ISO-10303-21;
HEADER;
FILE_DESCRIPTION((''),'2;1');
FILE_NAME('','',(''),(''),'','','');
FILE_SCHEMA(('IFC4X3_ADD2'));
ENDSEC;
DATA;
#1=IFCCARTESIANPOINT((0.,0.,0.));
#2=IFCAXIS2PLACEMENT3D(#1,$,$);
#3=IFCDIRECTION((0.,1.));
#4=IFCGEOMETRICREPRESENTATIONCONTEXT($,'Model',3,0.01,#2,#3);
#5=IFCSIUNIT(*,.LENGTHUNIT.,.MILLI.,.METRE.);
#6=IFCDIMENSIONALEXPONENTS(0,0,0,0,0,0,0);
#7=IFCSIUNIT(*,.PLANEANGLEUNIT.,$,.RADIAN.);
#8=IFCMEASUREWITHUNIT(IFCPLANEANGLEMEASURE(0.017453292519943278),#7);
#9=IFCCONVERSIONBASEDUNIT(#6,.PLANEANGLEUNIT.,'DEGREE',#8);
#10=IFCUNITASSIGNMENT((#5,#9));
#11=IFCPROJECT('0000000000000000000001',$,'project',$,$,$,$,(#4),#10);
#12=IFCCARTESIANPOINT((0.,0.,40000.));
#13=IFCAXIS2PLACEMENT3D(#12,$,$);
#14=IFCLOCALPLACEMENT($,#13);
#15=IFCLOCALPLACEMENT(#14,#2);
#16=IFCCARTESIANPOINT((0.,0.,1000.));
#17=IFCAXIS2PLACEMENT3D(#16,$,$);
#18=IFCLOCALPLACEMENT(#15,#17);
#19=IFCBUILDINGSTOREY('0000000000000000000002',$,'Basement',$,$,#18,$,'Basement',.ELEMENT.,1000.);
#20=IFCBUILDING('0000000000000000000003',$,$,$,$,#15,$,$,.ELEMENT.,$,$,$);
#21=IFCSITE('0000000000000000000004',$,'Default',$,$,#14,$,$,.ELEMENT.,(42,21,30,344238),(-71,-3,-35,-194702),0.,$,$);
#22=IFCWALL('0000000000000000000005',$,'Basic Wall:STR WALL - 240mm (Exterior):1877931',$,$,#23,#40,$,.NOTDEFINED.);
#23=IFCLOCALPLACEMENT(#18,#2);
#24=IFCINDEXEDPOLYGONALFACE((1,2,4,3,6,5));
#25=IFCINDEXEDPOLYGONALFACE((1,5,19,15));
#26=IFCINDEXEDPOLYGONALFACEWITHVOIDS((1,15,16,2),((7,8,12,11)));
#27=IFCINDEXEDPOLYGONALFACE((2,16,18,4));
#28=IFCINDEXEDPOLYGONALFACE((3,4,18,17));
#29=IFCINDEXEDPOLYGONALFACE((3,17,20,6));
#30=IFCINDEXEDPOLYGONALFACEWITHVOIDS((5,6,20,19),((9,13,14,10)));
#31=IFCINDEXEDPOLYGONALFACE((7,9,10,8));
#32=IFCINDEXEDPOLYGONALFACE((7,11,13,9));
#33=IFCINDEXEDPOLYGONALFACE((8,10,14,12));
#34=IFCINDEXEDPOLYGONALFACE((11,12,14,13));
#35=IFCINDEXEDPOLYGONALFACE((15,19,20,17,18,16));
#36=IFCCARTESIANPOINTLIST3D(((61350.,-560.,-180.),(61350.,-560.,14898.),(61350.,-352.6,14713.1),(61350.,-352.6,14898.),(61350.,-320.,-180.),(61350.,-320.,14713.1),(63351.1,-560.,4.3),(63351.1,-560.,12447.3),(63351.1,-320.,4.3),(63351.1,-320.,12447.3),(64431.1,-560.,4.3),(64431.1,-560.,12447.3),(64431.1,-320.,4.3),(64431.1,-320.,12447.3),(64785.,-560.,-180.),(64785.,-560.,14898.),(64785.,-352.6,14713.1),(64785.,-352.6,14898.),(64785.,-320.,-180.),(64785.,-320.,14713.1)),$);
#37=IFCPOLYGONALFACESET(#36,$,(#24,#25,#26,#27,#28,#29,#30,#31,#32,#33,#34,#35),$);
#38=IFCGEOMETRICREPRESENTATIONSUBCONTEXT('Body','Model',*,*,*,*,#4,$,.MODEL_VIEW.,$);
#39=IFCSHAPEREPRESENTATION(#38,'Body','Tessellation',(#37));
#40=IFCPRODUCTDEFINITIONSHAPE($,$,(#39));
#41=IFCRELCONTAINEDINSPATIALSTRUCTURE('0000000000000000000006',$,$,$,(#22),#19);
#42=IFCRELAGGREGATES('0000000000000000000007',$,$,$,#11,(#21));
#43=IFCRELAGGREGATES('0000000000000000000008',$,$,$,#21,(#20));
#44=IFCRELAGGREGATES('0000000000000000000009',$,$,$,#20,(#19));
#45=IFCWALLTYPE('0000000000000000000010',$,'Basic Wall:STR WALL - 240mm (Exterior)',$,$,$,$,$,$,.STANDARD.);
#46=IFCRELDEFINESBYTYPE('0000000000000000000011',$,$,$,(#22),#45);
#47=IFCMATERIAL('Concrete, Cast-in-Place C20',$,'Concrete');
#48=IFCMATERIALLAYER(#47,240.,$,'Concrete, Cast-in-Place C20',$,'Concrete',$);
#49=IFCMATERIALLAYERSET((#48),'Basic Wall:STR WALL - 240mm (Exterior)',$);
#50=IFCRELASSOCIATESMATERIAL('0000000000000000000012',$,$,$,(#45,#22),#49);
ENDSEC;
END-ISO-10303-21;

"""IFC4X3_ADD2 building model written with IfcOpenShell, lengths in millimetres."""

from ifc_helpers import new_model, entity, si_unit, converted_unit, direction, frame, frame_2d, origin, place, context, subcontext, project, spatial, polyline, rectangle, extrude, clip, bounded_halfspace, material, layer, layer_set, type_object, element, save


model = new_model("IFC4X3_ADD2")

# Units and contexts
model_context = context("Model", 3, precision=0.01, world=origin(), true_north=direction((0.0, 1.0)))
body_context = subcontext(model_context, "Body", "Model", "MODEL_VIEW")
ifc_project = project(units=[si_unit("LENGTHUNIT", "METRE", prefix="MILLI"), converted_unit("PLANEANGLEUNIT", "DEGREE", entity("IfcPlaneAngleMeasure", 0.017453292519943278), si_unit("PLANEANGLEUNIT", "RADIAN"), dimensions=[0, 0, 0, 0, 0, 0, 0])], contexts=[model_context])

# Site, building, storey
site_placement = place(None, frame((0.0, 0.0, 40000.0)))
site = spatial("IfcSite", under=ifc_project, at=site_placement, Name="Default", CompositionType="ELEMENT", RefLatitude=(42, 21, 30, 344238), RefLongitude=(-71, -3, -35, -194702), RefElevation=0.0)
building_placement = place(site_placement, origin())
building = spatial("IfcBuilding", under=site, at=building_placement, CompositionType="ELEMENT")
storey_placement = place(building_placement, frame((0.0, 0.0, 1000.0)))
storey = spatial("IfcBuildingStorey", under=building, at=storey_placement, Name="Basement", LongName="Basement", CompositionType="ELEMENT", Elevation=1000.0)

# Shared definitions
ifc_material_1 = material(Name="Concrete, Cast-in-Place C20", Category="Concrete")
ifc_layer = layer(ifc_material_1, 240.0, Name="Concrete, Cast-in-Place C20", Category="Concrete")
ifc_layer_set = layer_set([ifc_layer], Name="Basic Wall:STR WALL - 240mm (Exterior)")
wall_type = type_object("IfcWallType", Name="Basic Wall:STR WALL - 240mm (Exterior)", PredefinedType="STANDARD", material=ifc_layer_set)

# Wall, opening
wall_1_placement = place(storey_placement, frame((64785.0, -440.0, -180.0), z_axis=(0.0, 0.0, 1.0), x_axis=(-1.0, 0.0, 0.0)))
wall_1 = element("IfcWall", 1, at=wall_1_placement, inside=storey, type_object=wall_type, material=ifc_layer_set, Name="Basic Wall:STR WALL - 240mm (Exterior):1877931", PredefinedType="NOTDEFINED", context=body_context, shape_type="Clipping", body=[
    clip(clip(extrude(rectangle(XDim=3435.0, YDim=240.0, at=frame_2d((1717.5, 0.0), x_axis=(-1.0, 0.0))), origin(), (0.0, 0.0, 1.0), 15078.0), bounded_halfspace(frame((3435.0, -87.4, 15078.0), z_axis=(0.0, 0.0, -1.0), x_axis=(0.0, 1.0, 0.0)), True, frame((3435.0, -87.4, 15078.0)), polyline([(0.0, 0.0), (0.0, 207.4), (-3195.0, 207.4), (-3435.0, 207.4), (-3435.0, 0.0), (0.0, 0.0)]))), bounded_halfspace(frame((0.0, -120.0, 14893.1), z_axis=(0.0, 0.0, 1.0), x_axis=(0.0, 1.0, 0.0)), False, frame((0.0, -120.0, 14893.1)), polyline([(0.0, 0.0), (3435.0, 0.0), (3435.0, 32.6), (0.0, 32.6), (0.0, 0.0)]))),
])
opening_1_placement = place(wall_1_placement, frame((1433.9, 120.0, 184.3)))
element("IfcOpeningElement", 2, at=opening_1_placement, cuts=wall_1, PredefinedType="OPENING", context=body_context, shape_type="SweptSolid", body=[
    extrude(rectangle(XDim=12443.0, YDim=1080.0, at=frame_2d((0.0, 0.0), x_axis=(1.0, 0.0))), frame((-540.0, -240.0, 6221.5), z_axis=(0.0, 1.0, 0.0), x_axis=(0.0, 0.0, -1.0)), (0.0, 0.0, 1.0), 240.0),
])

save(model, "model.ifc")
